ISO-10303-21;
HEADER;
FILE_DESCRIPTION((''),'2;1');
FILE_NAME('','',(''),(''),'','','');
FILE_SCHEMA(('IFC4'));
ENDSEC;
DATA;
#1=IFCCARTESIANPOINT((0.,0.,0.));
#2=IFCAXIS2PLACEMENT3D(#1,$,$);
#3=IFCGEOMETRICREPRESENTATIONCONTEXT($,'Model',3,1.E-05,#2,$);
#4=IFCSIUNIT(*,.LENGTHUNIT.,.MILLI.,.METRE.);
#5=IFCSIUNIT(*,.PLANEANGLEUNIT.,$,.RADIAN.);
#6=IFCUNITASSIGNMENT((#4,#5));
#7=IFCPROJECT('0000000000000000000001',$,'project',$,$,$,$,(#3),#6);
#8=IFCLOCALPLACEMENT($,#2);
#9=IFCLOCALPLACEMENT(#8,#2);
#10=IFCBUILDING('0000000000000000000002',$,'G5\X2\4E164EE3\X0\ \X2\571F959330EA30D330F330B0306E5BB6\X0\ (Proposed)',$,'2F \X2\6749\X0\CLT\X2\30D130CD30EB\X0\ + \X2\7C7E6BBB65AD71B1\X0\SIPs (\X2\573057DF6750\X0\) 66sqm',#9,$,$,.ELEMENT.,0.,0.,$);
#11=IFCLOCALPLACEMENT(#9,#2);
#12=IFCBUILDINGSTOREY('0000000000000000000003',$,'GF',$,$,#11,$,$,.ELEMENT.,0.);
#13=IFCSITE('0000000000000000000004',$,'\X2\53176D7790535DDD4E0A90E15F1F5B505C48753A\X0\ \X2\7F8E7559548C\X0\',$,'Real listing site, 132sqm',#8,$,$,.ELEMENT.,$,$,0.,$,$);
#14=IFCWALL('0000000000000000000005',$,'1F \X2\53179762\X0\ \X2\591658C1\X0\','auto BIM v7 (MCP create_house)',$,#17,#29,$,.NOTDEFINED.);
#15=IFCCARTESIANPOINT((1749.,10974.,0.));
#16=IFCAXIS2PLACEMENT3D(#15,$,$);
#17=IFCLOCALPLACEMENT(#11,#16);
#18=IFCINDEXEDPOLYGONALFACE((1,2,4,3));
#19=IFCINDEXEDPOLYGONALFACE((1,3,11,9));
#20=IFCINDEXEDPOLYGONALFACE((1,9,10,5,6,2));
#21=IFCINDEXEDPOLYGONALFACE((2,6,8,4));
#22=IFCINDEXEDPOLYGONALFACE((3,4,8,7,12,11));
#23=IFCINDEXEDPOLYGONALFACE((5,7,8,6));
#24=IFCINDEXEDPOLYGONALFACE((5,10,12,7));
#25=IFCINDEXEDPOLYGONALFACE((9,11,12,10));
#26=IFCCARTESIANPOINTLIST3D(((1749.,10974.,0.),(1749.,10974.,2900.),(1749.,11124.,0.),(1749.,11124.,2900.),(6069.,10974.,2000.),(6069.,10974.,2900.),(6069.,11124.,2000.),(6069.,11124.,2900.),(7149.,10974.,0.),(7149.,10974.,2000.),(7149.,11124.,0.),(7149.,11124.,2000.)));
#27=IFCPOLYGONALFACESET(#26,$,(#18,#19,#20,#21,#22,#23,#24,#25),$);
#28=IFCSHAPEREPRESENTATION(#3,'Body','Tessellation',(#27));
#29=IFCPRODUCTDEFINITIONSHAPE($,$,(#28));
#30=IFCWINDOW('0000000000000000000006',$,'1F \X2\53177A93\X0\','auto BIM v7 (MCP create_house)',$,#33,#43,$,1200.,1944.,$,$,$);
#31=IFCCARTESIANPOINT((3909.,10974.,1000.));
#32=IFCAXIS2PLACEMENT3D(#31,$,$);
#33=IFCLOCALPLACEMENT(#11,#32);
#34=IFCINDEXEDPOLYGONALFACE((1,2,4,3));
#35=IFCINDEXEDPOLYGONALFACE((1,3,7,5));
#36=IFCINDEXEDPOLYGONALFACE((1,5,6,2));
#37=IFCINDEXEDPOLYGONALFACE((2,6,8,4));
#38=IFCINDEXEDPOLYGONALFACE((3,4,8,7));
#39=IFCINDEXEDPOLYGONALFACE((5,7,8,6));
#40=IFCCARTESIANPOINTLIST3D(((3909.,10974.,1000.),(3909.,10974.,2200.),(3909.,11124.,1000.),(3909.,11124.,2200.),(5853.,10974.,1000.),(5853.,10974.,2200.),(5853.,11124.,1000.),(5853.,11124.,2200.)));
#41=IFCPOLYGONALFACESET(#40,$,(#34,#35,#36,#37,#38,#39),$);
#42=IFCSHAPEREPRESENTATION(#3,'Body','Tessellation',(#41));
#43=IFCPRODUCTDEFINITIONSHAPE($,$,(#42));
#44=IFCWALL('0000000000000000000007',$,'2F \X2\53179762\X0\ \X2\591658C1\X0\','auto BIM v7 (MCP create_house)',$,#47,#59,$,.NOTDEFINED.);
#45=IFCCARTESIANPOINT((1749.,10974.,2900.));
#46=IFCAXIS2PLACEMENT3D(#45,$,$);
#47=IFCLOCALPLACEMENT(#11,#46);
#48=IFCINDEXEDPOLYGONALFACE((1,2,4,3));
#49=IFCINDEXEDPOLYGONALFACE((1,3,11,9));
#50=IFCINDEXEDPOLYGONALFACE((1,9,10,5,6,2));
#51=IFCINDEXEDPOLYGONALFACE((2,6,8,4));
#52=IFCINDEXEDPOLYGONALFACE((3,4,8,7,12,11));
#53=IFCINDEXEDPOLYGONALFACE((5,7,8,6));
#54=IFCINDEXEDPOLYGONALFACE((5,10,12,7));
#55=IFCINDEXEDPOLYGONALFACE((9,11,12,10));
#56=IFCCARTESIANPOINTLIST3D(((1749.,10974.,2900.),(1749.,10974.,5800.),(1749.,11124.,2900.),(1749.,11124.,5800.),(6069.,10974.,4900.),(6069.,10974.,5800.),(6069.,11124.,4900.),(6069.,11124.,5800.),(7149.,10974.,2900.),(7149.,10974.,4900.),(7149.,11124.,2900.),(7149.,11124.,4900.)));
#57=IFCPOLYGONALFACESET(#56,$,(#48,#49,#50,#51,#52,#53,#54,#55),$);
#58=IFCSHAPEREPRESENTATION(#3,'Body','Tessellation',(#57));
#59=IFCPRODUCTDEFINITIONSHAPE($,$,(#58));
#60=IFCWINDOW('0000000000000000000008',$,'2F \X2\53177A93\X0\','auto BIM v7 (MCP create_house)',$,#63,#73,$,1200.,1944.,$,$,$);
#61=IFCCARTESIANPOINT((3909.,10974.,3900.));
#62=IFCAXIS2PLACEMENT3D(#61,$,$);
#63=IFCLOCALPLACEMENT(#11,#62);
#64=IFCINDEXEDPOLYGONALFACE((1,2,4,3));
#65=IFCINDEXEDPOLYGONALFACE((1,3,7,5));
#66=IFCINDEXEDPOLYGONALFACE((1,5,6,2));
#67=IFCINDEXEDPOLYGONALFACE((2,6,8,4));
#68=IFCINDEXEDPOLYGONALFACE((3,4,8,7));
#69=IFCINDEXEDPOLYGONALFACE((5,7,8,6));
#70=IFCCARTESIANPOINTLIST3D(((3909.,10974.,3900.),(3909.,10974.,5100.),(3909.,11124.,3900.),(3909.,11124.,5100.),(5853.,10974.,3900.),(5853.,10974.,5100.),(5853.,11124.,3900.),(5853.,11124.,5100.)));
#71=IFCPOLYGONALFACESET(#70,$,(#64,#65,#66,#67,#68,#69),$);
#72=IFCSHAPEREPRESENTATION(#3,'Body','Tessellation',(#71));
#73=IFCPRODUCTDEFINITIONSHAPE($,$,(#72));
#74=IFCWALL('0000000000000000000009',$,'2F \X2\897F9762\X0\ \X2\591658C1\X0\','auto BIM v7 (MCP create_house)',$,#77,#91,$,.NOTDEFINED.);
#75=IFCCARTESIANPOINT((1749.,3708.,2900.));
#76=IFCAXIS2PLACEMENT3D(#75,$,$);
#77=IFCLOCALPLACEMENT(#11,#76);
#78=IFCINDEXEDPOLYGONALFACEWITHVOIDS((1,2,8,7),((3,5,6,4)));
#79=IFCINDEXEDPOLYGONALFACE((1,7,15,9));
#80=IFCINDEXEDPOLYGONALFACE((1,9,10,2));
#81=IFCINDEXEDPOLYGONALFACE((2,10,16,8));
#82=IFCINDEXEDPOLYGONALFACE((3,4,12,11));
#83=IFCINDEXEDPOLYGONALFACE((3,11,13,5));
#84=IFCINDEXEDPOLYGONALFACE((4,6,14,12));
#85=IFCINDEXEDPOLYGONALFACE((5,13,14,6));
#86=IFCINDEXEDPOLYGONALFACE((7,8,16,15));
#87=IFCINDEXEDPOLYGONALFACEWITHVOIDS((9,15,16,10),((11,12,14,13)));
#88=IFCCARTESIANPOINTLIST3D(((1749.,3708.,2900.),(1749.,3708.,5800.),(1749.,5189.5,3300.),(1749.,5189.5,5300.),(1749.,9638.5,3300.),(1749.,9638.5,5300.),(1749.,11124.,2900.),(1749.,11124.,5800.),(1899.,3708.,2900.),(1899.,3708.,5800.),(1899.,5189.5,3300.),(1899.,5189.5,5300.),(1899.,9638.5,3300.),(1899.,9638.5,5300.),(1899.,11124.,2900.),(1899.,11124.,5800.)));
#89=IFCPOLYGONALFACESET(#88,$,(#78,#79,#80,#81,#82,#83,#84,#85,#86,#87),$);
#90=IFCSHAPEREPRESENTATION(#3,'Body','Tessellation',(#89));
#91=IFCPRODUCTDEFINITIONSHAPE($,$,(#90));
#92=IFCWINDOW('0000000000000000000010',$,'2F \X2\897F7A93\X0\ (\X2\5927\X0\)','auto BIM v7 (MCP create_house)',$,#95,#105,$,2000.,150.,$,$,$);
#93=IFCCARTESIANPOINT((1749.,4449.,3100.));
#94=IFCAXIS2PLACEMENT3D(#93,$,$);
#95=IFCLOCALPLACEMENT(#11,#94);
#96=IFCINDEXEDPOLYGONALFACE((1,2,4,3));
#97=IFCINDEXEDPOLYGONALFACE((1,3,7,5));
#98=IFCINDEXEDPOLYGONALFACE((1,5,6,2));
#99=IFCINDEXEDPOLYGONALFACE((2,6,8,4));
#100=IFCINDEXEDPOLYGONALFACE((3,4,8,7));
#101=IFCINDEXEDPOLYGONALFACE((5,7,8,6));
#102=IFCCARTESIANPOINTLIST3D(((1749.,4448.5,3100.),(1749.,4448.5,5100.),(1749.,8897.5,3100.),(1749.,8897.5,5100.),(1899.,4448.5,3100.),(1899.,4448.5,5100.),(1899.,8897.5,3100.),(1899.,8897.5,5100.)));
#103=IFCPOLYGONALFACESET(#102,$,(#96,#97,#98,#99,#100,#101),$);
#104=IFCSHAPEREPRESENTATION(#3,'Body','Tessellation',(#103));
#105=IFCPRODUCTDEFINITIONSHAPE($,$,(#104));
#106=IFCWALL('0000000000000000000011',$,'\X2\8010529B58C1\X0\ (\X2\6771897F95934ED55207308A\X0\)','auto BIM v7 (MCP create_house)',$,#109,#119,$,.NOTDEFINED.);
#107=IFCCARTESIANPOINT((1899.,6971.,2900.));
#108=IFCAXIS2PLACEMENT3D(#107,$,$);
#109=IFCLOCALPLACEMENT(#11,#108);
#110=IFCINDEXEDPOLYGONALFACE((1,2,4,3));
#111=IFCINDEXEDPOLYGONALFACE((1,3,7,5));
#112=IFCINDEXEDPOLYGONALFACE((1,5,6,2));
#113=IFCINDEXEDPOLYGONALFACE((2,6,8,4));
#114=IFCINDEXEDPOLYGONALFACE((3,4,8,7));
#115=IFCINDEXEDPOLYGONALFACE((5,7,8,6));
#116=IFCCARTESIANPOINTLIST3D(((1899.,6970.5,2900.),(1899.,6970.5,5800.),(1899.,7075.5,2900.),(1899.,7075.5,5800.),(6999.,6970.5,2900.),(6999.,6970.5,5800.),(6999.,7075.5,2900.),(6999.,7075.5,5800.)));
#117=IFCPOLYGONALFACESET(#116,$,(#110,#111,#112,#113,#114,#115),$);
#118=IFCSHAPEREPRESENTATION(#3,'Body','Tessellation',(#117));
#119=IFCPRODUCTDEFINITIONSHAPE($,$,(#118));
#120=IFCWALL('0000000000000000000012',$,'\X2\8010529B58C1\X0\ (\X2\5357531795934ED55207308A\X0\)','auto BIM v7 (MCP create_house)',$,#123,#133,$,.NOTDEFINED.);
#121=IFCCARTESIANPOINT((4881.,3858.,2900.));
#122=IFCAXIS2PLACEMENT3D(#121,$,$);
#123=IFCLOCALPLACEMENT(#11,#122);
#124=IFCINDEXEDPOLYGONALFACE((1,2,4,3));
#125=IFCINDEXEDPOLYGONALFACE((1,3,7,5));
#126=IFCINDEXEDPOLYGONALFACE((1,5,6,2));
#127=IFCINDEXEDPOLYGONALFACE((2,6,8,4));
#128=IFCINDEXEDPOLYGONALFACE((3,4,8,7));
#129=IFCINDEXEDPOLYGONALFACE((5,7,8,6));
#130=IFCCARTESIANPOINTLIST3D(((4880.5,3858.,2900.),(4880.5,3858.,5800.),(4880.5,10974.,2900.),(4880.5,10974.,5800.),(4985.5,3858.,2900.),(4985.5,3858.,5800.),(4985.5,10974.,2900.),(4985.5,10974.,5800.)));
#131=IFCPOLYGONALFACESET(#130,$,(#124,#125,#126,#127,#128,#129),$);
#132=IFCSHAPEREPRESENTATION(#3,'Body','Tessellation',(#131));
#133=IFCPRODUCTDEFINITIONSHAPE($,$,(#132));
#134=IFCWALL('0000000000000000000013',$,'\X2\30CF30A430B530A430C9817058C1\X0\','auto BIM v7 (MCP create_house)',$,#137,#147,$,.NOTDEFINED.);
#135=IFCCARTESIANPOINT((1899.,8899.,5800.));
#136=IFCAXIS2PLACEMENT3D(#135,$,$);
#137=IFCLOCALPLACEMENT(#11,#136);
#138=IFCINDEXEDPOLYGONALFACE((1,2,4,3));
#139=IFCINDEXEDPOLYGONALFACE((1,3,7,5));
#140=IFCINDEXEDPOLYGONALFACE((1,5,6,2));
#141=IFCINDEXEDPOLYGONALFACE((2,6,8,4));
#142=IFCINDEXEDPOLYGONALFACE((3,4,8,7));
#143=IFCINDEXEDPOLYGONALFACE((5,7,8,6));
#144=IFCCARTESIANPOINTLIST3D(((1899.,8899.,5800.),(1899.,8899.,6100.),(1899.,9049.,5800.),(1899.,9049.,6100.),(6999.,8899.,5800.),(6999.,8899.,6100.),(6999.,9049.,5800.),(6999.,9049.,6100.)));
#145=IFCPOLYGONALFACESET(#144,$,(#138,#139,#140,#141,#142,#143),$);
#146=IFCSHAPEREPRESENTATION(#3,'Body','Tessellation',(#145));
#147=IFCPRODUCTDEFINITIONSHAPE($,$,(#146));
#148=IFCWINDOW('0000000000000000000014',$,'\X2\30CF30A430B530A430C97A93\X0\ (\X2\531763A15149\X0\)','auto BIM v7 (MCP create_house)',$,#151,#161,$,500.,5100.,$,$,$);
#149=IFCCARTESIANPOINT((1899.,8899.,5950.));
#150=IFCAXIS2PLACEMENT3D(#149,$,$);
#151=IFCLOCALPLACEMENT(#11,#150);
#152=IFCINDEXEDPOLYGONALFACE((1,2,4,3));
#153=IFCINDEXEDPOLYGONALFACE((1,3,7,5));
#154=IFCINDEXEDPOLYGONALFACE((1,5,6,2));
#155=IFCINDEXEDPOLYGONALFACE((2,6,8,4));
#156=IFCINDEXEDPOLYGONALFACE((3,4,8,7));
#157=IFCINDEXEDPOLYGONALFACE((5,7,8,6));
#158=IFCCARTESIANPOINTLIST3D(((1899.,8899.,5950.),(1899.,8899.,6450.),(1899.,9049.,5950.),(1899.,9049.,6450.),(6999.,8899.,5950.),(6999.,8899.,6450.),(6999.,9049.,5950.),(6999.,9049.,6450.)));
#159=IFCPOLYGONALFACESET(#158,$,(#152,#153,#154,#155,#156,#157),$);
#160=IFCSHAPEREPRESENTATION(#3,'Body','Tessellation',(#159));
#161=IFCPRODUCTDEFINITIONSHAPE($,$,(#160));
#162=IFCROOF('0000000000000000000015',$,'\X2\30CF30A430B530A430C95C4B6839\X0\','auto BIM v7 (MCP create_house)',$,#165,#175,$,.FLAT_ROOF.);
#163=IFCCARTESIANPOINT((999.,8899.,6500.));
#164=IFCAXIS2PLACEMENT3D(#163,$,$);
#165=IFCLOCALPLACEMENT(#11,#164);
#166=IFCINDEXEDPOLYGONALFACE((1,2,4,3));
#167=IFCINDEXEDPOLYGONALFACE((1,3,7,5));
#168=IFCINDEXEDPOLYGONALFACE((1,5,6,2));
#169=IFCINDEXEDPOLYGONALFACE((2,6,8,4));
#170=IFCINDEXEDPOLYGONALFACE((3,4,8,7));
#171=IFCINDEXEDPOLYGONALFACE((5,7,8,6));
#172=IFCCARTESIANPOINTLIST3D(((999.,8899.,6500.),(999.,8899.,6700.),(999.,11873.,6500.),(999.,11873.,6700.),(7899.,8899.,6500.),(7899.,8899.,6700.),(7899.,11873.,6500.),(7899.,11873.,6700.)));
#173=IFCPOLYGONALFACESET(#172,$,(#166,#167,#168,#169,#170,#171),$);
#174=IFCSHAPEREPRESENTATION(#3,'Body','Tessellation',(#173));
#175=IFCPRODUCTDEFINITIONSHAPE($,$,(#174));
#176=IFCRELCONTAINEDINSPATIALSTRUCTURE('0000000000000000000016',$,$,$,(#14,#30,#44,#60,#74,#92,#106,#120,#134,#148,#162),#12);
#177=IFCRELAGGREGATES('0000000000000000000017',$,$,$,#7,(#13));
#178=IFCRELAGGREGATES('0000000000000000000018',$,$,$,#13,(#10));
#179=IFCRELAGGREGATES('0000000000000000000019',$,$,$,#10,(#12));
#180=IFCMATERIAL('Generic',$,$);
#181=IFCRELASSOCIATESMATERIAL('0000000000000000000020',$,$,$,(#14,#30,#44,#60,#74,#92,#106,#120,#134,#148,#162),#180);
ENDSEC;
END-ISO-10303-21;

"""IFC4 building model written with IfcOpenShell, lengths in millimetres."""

from ifc_helpers import new_model, si_unit, frame, frame_2d, origin, place, context, project, spatial, rectangle, extrude, material, element, fill, save


model = new_model("IFC4")

# Units and contexts
model_context = context("Model", 3, precision=1e-05, world=origin())
ifc_project = project(units=[si_unit("LENGTHUNIT", "METRE", prefix="MILLI"), si_unit("PLANEANGLEUNIT", "RADIAN")], contexts=[model_context])

# Site, building, storey
site_placement = place(None, origin())
site = spatial("IfcSite", under=ifc_project, at=site_placement, Name="北海道川上郡弟子屈町 美留和", ObjectType="Real listing site, 132sqm", CompositionType="ELEMENT", RefElevation=0.0)
building_placement = place(site_placement, origin())
building = spatial("IfcBuilding", under=site, at=building_placement, Name="G5世代 土間リビングの家 (Proposed)", ObjectType="2F 杉CLTパネル + 籾殻断熱SIPs (地域材) 66sqm", CompositionType="ELEMENT", ElevationOfRefHeight=0.0, ElevationOfTerrain=0.0)
storey_placement = place(building_placement, origin())
storey = spatial("IfcBuildingStorey", under=building, at=storey_placement, Name="GF", CompositionType="ELEMENT", Elevation=0.0)

# Wall, opening, window
ifc_material = material(Name="Generic")
wall_1_placement = place(storey_placement, frame((1749.0, 10974.0, 0.0)))
wall_1 = element("IfcWall", 1, at=wall_1_placement, inside=storey, material=ifc_material, Name="1F 北面 外壁", Description="auto BIM v7 (MCP create_house)", PredefinedType="NOTDEFINED", context=model_context, shape_type="SweptSolid", body=[
    extrude(rectangle(XDim=5400.0, YDim=150.0, at=frame_2d((2700.0, 75.0))), frame((1749.0, 10974.0, 0.0)), (0.0, 0.0, 1.0), 2900.0),
])
opening_1_placement = place(storey_placement, frame((3909.0, 10974.0, 1000.0)))
opening_1 = element("IfcOpeningElement", 2, at=opening_1_placement, cuts=wall_1, PredefinedType="NOTDEFINED", context=model_context, shape_type="SweptSolid", body=[
    extrude(rectangle(XDim=1944.0, YDim=150.0, at=frame_2d((972.0, 75.0))), frame((3909.0, 10974.0, 1000.0)), (0.0, 0.0, 1.0), 1200.0),
])
window_1_placement = place(storey_placement, frame((3909.0, 10974.0, 1000.0)))
window_1 = element("IfcWindow", 3, at=window_1_placement, inside=storey, material=ifc_material, Name="1F 北窓", Description="auto BIM v7 (MCP create_house)", OverallHeight=1200.0, OverallWidth=1944.0, context=model_context, shape_type="SweptSolid", body=[
    extrude(rectangle(XDim=1944.0, YDim=150.0, at=frame_2d((972.0, 75.0))), frame((3909.0, 10974.0, 1000.0)), (0.0, 0.0, 1.0), 1200.0),
])
fill(opening_1, window_1)

# Walls, openings, windows
wall_2_placement = place(storey_placement, frame((1749.0, 10974.0, 2900.0)))
wall_2 = element("IfcWall", 4, at=wall_2_placement, inside=storey, material=ifc_material, Name="2F 北面 外壁", Description="auto BIM v7 (MCP create_house)", PredefinedType="NOTDEFINED", context=model_context, shape_type="SweptSolid", body=[
    extrude(rectangle(XDim=5400.0, YDim=150.0, at=frame_2d((2700.0, 75.0))), frame((1749.0, 10974.0, 2900.0)), (0.0, 0.0, 1.0), 2900.0),
])
opening_2_placement = place(storey_placement, frame((3909.0, 10974.0, 3900.0)))
opening_2 = element("IfcOpeningElement", 5, at=opening_2_placement, cuts=wall_2, PredefinedType="NOTDEFINED", context=model_context, shape_type="SweptSolid", body=[
    extrude(rectangle(XDim=1944.0, YDim=150.0, at=frame_2d((972.0, 75.0))), frame((3909.0, 10974.0, 3900.0)), (0.0, 0.0, 1.0), 1200.0),
])
window_2_placement = place(storey_placement, frame((3909.0, 10974.0, 3900.0)))
window_2 = element("IfcWindow", 6, at=window_2_placement, inside=storey, material=ifc_material, Name="2F 北窓", Description="auto BIM v7 (MCP create_house)", OverallHeight=1200.0, OverallWidth=1944.0, context=model_context, shape_type="SweptSolid", body=[
    extrude(rectangle(XDim=1944.0, YDim=150.0, at=frame_2d((972.0, 75.0))), frame((3909.0, 10974.0, 3900.0)), (0.0, 0.0, 1.0), 1200.0),
])
fill(opening_2, window_2)
wall_3_placement = place(storey_placement, frame((1749.0, 3708.0, 2900.0)))
wall_3 = element("IfcWall", 7, at=wall_3_placement, inside=storey, material=ifc_material, Name="2F 西面 外壁", Description="auto BIM v7 (MCP create_house)", PredefinedType="NOTDEFINED", context=model_context, shape_type="SweptSolid", body=[
    extrude(rectangle(XDim=150.0, YDim=7416.0, at=frame_2d((75.0, 3708.0))), frame((1749.0, 3708.0, 2900.0)), (0.0, 0.0, 1.0), 2900.0),
])
opening_3_placement = place(storey_placement, frame((1749.0, 4449.0, 3100.0)))
opening_3 = element("IfcOpeningElement", 8, at=opening_3_placement, cuts=wall_3, PredefinedType="NOTDEFINED", context=model_context, shape_type="SweptSolid", body=[
    extrude(rectangle(XDim=150.0, YDim=4449.0, at=frame_2d((75.0, 2224.0))), frame((1749.0, 4449.0, 3100.0)), (0.0, 0.0, 1.0), 2000.0),
])
window_3_placement = place(storey_placement, frame((1749.0, 4449.0, 3100.0)))
window_3 = element("IfcWindow", 9, at=window_3_placement, inside=storey, material=ifc_material, Name="2F 西窓 (大)", Description="auto BIM v7 (MCP create_house)", OverallHeight=2000.0, OverallWidth=150.0, context=model_context, shape_type="SweptSolid", body=[
    extrude(rectangle(XDim=150.0, YDim=4449.0, at=frame_2d((75.0, 2224.0))), frame((1749.0, 4449.0, 3100.0)), (0.0, 0.0, 1.0), 2000.0),
])
fill(opening_3, window_3)

# Walls
wall_4_placement = place(storey_placement, frame((1899.0, 6971.0, 2900.0)))
element("IfcWall", 10, at=wall_4_placement, inside=storey, material=ifc_material, Name="耐力壁 (東西間仕切り)", Description="auto BIM v7 (MCP create_house)", PredefinedType="NOTDEFINED", context=model_context, shape_type="SweptSolid", body=[
    extrude(rectangle(XDim=5100.0, YDim=105.0, at=frame_2d((2550.0, 52.0))), frame((1899.0, 6971.0, 2900.0)), (0.0, 0.0, 1.0), 2900.0),
])
wall_5_placement = place(storey_placement, frame((4881.0, 3858.0, 2900.0)))
element("IfcWall", 11, at=wall_5_placement, inside=storey, material=ifc_material, Name="耐力壁 (南北間仕切り)", Description="auto BIM v7 (MCP create_house)", PredefinedType="NOTDEFINED", context=model_context, shape_type="SweptSolid", body=[
    extrude(rectangle(XDim=105.0, YDim=7116.0, at=frame_2d((52.0, 3558.0))), frame((4881.0, 3858.0, 2900.0)), (0.0, 0.0, 1.0), 2900.0),
])

# Wall, opening, window
wall_6_placement = place(storey_placement, frame((1899.0, 8899.0, 5800.0)))
wall_6 = element("IfcWall", 12, at=wall_6_placement, inside=storey, material=ifc_material, Name="ハイサイド腰壁", Description="auto BIM v7 (MCP create_house)", PredefinedType="NOTDEFINED", context=model_context, shape_type="SweptSolid", body=[
    extrude(rectangle(XDim=5100.0, YDim=150.0, at=frame_2d((2550.0, 75.0))), frame((1899.0, 8899.0, 5800.0)), (0.0, 0.0, 1.0), 700.0),
])
opening_4_placement = place(storey_placement, frame((1899.0, 8899.0, 5950.0)))
opening_4 = element("IfcOpeningElement", 13, at=opening_4_placement, cuts=wall_6, PredefinedType="NOTDEFINED", context=model_context, shape_type="SweptSolid", body=[
    extrude(rectangle(XDim=5100.0, YDim=150.0, at=frame_2d((2550.0, 75.0))), frame((1899.0, 8899.0, 5950.0)), (0.0, 0.0, 1.0), 500.0),
])
window_4_placement = place(storey_placement, frame((1899.0, 8899.0, 5950.0)))
window_4 = element("IfcWindow", 14, at=window_4_placement, inside=storey, material=ifc_material, Name="ハイサイド窓 (北採光)", Description="auto BIM v7 (MCP create_house)", OverallHeight=500.0, OverallWidth=5100.0, context=model_context, shape_type="SweptSolid", body=[
    extrude(rectangle(XDim=5100.0, YDim=150.0, at=frame_2d((2550.0, 75.0))), frame((1899.0, 8899.0, 5950.0)), (0.0, 0.0, 1.0), 500.0),
])
fill(opening_4, window_4)

# Roof
roof_placement = place(storey_placement, frame((999.0, 8899.0, 6500.0)))
element("IfcRoof", 15, at=roof_placement, inside=storey, material=ifc_material, Name="ハイサイド屋根", Description="auto BIM v7 (MCP create_house)", PredefinedType="FLAT_ROOF", context=model_context, shape_type="SweptSolid", body=[
    extrude(rectangle(XDim=6900.0, YDim=2974.0, at=frame_2d((3450.0, 1487.0))), frame((999.0, 8899.0, 6500.0)), (0.0, 0.0, 1.0), 200.0),
])

save(model, "model.ifc")
